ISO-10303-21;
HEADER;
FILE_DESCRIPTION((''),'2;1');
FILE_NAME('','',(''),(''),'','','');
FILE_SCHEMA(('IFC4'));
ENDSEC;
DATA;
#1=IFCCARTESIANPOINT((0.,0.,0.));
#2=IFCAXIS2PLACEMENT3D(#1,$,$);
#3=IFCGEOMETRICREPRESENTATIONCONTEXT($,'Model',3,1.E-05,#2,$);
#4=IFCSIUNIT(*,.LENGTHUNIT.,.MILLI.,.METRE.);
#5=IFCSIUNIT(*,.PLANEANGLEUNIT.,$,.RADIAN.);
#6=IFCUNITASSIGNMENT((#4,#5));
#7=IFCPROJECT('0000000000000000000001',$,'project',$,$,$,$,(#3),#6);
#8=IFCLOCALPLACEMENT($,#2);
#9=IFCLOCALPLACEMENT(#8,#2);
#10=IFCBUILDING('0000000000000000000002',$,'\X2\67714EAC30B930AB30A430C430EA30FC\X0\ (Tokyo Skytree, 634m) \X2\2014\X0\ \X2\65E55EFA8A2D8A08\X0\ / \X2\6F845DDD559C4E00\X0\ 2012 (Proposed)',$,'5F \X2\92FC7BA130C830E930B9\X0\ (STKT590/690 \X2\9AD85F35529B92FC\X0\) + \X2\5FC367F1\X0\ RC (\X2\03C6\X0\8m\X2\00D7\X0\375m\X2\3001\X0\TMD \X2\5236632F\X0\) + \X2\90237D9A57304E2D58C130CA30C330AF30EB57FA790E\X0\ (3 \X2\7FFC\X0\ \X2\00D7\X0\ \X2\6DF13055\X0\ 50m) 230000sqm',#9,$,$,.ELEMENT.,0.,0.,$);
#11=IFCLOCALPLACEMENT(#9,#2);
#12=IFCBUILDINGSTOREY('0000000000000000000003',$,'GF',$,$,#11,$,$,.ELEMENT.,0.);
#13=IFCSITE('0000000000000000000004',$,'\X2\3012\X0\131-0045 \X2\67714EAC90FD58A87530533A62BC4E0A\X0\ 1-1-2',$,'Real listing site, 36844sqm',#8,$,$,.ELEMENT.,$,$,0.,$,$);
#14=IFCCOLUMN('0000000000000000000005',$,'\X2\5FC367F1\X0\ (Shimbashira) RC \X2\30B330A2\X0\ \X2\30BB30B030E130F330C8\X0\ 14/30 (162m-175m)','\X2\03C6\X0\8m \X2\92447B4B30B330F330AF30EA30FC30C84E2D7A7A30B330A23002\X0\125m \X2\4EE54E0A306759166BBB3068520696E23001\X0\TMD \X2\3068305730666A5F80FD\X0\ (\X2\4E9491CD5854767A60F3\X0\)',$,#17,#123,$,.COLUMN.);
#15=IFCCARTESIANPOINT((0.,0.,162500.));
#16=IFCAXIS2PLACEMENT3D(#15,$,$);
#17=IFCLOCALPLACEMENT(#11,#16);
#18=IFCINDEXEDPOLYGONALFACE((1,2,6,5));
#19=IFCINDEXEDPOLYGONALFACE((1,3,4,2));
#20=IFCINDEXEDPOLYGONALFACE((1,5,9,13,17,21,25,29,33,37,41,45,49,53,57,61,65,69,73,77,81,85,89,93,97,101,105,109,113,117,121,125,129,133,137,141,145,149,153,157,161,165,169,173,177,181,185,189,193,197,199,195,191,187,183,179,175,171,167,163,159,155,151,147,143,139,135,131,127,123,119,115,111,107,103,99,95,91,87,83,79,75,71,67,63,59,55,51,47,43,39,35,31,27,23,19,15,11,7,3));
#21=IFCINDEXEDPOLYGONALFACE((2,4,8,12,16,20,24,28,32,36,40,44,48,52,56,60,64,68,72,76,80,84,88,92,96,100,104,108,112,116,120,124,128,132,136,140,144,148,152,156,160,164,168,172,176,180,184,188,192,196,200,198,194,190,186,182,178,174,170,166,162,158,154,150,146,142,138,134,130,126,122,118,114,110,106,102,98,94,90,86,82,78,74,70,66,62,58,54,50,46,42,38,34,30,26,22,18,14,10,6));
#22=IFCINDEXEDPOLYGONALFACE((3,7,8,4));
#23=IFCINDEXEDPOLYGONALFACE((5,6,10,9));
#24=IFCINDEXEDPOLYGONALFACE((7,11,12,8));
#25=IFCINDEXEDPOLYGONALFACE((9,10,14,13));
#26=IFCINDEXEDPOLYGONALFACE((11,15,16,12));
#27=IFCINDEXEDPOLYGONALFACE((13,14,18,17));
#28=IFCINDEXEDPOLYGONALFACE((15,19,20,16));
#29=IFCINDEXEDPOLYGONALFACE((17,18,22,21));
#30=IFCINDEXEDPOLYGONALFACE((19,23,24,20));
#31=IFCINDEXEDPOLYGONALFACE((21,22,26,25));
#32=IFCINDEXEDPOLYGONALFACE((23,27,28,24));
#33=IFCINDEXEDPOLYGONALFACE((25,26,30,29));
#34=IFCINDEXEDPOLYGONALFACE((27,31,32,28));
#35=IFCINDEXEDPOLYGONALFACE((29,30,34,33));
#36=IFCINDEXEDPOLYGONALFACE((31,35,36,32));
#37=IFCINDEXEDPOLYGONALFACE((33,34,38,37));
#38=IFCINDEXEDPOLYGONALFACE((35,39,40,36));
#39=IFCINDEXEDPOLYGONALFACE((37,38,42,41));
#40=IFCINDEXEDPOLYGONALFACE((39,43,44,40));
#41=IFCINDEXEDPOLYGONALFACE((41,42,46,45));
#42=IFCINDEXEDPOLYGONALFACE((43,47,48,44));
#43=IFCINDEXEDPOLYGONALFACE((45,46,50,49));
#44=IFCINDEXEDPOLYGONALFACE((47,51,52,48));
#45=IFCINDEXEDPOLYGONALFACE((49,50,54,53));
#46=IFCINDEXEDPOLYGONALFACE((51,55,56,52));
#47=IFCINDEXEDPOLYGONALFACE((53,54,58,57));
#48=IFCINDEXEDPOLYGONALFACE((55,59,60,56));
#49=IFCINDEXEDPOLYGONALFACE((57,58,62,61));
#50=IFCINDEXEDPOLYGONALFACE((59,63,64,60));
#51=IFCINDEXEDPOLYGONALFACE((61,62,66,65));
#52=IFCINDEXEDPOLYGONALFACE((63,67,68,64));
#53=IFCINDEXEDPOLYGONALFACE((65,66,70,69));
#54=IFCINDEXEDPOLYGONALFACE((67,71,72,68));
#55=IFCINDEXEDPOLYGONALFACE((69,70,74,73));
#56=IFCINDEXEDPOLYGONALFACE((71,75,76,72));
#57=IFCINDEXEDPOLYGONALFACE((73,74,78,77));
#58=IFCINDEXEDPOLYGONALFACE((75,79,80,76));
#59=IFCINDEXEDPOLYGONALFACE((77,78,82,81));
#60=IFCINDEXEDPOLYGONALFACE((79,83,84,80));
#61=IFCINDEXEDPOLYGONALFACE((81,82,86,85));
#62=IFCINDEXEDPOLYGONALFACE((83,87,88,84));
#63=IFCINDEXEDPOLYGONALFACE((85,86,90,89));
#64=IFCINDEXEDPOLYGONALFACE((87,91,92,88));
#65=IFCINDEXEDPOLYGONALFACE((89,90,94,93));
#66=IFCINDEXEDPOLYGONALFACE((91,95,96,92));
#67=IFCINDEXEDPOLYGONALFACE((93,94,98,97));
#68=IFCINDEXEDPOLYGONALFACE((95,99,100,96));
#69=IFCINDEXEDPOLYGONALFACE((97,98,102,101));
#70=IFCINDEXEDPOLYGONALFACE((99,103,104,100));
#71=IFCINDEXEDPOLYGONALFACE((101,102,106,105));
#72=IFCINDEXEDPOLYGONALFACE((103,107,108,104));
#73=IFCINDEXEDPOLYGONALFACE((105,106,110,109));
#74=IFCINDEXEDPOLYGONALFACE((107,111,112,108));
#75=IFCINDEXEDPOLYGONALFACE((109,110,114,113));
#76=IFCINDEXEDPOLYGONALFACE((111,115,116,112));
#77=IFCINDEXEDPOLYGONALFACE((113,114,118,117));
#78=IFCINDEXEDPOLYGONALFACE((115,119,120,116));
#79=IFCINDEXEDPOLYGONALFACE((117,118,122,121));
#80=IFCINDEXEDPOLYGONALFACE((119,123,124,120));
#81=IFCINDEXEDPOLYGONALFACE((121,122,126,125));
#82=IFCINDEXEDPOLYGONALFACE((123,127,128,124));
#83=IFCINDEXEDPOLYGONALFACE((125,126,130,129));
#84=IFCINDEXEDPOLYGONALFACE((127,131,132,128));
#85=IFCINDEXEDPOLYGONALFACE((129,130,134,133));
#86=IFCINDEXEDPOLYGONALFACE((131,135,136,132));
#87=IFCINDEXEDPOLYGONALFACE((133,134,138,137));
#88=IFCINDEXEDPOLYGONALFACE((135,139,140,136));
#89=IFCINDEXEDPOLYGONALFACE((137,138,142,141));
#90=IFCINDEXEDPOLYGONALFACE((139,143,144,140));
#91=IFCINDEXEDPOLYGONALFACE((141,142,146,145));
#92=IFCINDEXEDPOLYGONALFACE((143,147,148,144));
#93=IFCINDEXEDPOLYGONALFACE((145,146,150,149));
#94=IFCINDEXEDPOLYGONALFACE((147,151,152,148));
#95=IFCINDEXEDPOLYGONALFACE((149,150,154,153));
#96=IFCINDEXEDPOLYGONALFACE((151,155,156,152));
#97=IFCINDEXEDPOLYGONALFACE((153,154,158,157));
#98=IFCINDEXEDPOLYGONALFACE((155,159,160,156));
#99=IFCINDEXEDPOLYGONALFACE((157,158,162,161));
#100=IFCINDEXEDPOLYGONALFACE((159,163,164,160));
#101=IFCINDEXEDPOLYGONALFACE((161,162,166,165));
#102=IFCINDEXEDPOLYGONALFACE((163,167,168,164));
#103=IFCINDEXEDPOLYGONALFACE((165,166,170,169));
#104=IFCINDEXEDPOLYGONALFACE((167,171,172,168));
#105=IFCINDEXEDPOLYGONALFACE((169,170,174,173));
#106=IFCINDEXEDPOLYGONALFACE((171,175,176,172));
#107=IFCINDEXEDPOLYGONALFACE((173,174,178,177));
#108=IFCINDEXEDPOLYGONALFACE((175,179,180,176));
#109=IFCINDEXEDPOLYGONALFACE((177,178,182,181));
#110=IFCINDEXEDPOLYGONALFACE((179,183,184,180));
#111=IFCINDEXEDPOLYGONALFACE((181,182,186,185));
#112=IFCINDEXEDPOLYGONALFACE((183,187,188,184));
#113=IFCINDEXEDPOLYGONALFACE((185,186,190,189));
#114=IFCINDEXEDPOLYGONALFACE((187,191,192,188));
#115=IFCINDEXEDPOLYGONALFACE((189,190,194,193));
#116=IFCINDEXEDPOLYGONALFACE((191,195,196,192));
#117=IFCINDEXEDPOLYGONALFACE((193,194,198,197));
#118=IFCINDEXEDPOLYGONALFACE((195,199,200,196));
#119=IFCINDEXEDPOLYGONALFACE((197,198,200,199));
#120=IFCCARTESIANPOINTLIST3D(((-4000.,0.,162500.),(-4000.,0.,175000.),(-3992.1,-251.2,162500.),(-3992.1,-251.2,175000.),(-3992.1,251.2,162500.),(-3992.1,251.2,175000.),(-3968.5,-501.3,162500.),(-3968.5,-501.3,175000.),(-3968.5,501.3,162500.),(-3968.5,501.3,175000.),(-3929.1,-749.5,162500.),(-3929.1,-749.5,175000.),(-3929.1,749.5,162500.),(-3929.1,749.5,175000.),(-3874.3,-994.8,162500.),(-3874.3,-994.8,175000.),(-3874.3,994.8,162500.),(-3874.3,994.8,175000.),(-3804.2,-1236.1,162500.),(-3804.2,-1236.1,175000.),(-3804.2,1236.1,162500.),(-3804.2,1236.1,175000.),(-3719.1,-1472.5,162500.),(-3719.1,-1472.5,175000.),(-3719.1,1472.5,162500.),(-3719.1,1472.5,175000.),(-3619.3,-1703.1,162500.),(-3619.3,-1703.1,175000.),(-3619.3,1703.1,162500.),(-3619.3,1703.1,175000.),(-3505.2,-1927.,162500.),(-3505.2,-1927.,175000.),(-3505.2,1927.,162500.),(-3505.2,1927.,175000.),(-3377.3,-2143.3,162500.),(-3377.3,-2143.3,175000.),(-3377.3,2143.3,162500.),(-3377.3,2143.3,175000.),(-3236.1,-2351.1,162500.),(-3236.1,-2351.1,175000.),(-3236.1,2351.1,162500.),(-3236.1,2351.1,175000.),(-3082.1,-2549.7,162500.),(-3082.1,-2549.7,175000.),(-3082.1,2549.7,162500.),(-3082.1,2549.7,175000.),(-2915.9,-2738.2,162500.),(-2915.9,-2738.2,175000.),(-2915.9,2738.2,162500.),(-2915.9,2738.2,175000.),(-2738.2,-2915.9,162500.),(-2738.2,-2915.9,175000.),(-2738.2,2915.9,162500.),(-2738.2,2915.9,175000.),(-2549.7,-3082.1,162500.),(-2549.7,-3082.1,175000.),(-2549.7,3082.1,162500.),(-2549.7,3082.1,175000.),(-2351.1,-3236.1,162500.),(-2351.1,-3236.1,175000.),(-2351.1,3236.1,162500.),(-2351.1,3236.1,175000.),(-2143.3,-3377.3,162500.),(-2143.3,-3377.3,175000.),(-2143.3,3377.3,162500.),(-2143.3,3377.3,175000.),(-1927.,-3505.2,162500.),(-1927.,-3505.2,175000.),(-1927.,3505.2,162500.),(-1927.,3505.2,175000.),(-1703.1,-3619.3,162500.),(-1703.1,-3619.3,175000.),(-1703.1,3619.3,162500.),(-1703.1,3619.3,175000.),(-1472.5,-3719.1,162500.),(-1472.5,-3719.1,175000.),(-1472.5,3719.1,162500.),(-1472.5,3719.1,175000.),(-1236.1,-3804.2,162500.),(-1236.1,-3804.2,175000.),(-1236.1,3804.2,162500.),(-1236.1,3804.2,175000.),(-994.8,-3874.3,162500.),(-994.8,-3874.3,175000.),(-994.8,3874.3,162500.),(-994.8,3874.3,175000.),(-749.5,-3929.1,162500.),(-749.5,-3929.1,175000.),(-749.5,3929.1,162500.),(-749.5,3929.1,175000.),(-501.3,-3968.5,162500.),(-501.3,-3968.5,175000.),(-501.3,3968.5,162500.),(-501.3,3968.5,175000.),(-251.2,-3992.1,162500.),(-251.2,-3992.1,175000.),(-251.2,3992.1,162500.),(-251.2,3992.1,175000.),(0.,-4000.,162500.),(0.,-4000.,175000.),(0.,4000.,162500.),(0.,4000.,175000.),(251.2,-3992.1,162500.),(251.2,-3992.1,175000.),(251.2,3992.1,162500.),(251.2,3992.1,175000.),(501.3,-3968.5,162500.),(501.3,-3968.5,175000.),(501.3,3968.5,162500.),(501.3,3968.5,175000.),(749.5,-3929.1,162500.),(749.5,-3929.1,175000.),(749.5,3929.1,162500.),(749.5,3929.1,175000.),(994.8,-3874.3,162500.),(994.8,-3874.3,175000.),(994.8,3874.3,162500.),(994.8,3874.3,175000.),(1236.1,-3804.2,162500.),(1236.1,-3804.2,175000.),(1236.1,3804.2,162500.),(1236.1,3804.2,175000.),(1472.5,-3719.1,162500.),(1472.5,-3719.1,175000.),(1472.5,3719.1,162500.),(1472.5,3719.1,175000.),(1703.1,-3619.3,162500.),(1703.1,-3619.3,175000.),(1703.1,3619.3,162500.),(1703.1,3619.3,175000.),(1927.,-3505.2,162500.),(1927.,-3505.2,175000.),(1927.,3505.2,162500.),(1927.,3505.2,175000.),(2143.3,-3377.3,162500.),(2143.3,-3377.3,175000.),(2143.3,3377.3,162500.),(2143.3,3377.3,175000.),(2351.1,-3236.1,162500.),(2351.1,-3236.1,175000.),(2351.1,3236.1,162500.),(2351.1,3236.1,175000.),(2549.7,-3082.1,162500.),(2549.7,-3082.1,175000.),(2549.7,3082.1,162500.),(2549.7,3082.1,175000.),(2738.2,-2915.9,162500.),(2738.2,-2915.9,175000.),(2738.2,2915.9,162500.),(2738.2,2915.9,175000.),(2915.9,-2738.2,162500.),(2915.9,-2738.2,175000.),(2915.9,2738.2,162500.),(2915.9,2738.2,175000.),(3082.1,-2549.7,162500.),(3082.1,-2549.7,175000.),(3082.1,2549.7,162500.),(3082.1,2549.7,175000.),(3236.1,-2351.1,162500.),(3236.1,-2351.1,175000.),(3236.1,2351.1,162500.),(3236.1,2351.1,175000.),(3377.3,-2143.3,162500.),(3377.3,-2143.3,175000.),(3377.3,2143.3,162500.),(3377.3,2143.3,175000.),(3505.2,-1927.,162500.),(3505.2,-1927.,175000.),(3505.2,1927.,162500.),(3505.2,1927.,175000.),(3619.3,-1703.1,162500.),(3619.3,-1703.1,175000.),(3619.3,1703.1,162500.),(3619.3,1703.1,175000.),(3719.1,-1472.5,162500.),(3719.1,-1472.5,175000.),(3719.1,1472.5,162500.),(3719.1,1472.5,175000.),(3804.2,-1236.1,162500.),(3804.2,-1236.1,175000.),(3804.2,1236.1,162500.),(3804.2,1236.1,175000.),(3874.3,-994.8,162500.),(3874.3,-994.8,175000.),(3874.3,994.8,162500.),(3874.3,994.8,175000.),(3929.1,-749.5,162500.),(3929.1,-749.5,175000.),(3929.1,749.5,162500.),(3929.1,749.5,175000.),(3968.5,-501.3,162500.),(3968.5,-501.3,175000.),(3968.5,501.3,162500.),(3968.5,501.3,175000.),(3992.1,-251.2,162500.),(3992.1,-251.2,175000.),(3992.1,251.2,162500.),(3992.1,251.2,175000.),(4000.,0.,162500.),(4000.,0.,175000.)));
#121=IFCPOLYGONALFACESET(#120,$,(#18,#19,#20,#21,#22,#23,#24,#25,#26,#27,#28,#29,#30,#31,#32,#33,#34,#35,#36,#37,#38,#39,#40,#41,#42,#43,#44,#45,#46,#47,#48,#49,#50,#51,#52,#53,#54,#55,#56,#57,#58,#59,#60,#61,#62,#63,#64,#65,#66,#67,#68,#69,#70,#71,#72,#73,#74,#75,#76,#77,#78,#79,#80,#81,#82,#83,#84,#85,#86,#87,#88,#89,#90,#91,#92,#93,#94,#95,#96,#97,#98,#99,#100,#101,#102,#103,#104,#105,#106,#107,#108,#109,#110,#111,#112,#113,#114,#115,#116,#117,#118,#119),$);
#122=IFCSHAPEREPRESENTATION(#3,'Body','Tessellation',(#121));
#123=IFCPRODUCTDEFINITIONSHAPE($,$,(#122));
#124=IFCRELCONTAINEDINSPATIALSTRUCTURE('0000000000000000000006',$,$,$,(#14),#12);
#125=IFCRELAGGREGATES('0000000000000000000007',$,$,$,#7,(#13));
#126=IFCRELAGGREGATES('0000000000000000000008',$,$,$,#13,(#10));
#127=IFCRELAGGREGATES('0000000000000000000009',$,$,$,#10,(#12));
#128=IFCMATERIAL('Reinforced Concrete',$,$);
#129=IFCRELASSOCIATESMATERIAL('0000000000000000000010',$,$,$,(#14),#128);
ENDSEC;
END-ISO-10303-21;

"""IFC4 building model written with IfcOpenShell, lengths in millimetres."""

from ifc_helpers import new_model, si_unit, frame, origin, origin_2d, place, context, project, spatial, circle, extrude, material, element, save


model = new_model("IFC4")

# Units and contexts
model_context = context("Model", 3, precision=1e-05, world=origin())
ifc_project = project(units=[si_unit("LENGTHUNIT", "METRE", prefix="MILLI"), si_unit("PLANEANGLEUNIT", "RADIAN")], contexts=[model_context])

# Site, building, storey
site_placement = place(None, origin())
site = spatial("IfcSite", under=ifc_project, at=site_placement, Name="〒131-0045 東京都墨田区押上 1-1-2", ObjectType="Real listing site, 36844sqm", CompositionType="ELEMENT", RefElevation=0.0)
building_placement = place(site_placement, origin())
building = spatial("IfcBuilding", under=site, at=building_placement, Name="東京スカイツリー (Tokyo Skytree, 634m) — 日建設計 / 澄川喜一 2012 (Proposed)", ObjectType="5F 鋼管トラス (STKT590/690 高張力鋼) + 心柱 RC (φ8m×375m、TMD 制振) + 連続地中壁ナックル基礎 (3 翼 × 深さ 50m) 230000sqm", CompositionType="ELEMENT", ElevationOfRefHeight=0.0, ElevationOfTerrain=0.0)
storey_placement = place(building_placement, origin())
storey = spatial("IfcBuildingStorey", under=building, at=storey_placement, Name="GF", CompositionType="ELEMENT", Elevation=0.0)

# Column
ifc_material_1 = material(Name="Reinforced Concrete")
column_1_placement = place(storey_placement, frame((0.0, 0.0, 162500.0)))
element("IfcColumn", 1, at=column_1_placement, inside=storey, material=ifc_material_1, Name="心柱 (Shimbashira) RC コア セグメント 14/30 (162m-175m)", Description="φ8m 鉄筋コンクリート中空コア。125m 以上で外殻と分離、TMD として機能 (五重塔発想)", PredefinedType="COLUMN", context=model_context, shape_type="SweptSolid", body=[
    extrude(circle(Radius=4000.0, at=origin_2d()), frame((0.0, 0.0, 162500.0)), (0.0, 0.0, 1.0), 12500.0),
])

save(model, "model.ifc")
